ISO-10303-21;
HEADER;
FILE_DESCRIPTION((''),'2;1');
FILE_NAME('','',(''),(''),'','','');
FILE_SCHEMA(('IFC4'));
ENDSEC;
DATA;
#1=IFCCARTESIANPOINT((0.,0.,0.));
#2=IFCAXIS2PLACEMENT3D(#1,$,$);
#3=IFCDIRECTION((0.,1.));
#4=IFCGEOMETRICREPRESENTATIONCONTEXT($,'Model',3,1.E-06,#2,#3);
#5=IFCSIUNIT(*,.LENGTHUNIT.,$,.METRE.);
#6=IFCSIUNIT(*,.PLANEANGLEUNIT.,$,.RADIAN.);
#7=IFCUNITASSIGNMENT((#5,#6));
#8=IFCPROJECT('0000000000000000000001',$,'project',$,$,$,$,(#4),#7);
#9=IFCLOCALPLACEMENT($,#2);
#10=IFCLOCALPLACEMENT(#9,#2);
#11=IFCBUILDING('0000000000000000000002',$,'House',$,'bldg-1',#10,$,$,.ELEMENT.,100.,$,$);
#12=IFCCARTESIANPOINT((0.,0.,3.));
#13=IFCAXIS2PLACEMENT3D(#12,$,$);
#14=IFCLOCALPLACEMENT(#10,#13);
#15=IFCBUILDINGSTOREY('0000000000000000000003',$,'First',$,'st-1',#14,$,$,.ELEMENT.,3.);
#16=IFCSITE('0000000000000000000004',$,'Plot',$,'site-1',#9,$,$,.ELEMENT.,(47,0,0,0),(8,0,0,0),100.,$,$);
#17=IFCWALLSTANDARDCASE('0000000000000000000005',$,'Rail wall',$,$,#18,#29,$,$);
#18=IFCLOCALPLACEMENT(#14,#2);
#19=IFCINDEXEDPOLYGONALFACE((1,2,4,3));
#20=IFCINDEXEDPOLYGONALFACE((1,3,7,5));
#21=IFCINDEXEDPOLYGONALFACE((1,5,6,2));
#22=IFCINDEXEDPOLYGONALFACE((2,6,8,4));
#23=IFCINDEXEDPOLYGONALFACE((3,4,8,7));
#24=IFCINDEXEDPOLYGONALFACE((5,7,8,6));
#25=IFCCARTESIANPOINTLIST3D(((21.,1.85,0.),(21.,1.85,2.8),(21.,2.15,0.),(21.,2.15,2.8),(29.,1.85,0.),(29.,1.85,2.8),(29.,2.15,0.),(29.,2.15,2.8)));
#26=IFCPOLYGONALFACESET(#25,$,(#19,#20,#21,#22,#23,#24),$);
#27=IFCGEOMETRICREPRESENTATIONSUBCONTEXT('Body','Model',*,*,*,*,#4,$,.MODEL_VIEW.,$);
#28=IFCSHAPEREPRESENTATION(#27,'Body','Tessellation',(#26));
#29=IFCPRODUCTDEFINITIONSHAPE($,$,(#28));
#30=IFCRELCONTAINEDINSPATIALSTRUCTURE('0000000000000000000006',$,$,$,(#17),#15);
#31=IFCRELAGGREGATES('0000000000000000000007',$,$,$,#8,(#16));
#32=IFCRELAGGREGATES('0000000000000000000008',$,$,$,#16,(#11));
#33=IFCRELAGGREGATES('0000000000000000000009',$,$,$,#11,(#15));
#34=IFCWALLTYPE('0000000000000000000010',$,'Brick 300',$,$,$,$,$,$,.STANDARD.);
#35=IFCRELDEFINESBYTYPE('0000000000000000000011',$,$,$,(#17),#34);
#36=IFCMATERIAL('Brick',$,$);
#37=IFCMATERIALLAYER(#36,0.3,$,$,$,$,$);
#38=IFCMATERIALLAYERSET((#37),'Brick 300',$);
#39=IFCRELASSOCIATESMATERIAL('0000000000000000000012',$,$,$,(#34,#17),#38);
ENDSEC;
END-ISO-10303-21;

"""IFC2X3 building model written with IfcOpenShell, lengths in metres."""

from ifc_helpers import new_model, si_unit, direction, frame, frame_2d, origin, place, context, subcontext, project, spatial, rectangle, extrude, material, layer, layer_set, layer_usage, type_object, element, save


model = new_model("IFC2X3")

# Units and contexts
model_context = context("Model", 3, precision=1e-06, world=origin(), true_north=direction((0.0, 1.0)))
body_context = subcontext(model_context, "Body", "Model", "MODEL_VIEW")
ifc_project = project(units=[si_unit("LENGTHUNIT", "METRE"), si_unit("PLANEANGLEUNIT", "RADIAN")], contexts=[model_context])

# Site, building, storey
site_placement = place(None, origin())
site = spatial("IfcSite", under=ifc_project, at=site_placement, Name="Plot", ObjectType="site-1", CompositionType="ELEMENT", RefLatitude=(47, 0, 0, 0), RefLongitude=(8, 0, 0, 0), RefElevation=100.0)
building_placement = place(site_placement, origin())
building = spatial("IfcBuilding", under=site, at=building_placement, Name="House", ObjectType="bldg-1", CompositionType="ELEMENT", ElevationOfRefHeight=100.0)
storey_placement = place(building_placement, frame((0.0, 0.0, 3.0)))
storey = spatial("IfcBuildingStorey", under=building, at=storey_placement, Name="First", ObjectType="st-1", CompositionType="ELEMENT", Elevation=3.0)

# Wall
ifc_material_1 = material(Name="Brick")
ifc_layer = layer(ifc_material_1, 0.3)
ifc_layer_set = layer_set([ifc_layer], Name="Brick 300")
ifc_layer_usage = layer_usage(ifc_layer_set, "AXIS2", "NEGATIVE", 0.15)
wall_type = type_object("IfcWallType", Name="Brick 300", PredefinedType="STANDARD", material=ifc_layer_set)
wall_placement = place(storey_placement, frame((21.0, 2.0, 0.0), z_axis=(0.0, 0.0, 1.0), x_axis=(1.0, 0.0, 0.0)))
element("IfcWallStandardCase", 1, at=wall_placement, inside=storey, type_object=wall_type, material=ifc_layer_usage, Name="Rail wall", context=body_context, shape_type="SweptSolid", body=[
    extrude(rectangle(XDim=8.0, YDim=0.3, at=frame_2d((4.0, 0.0))), origin(), (0.0, 0.0, 1.0), 2.8),
])

save(model, "model.ifc")
